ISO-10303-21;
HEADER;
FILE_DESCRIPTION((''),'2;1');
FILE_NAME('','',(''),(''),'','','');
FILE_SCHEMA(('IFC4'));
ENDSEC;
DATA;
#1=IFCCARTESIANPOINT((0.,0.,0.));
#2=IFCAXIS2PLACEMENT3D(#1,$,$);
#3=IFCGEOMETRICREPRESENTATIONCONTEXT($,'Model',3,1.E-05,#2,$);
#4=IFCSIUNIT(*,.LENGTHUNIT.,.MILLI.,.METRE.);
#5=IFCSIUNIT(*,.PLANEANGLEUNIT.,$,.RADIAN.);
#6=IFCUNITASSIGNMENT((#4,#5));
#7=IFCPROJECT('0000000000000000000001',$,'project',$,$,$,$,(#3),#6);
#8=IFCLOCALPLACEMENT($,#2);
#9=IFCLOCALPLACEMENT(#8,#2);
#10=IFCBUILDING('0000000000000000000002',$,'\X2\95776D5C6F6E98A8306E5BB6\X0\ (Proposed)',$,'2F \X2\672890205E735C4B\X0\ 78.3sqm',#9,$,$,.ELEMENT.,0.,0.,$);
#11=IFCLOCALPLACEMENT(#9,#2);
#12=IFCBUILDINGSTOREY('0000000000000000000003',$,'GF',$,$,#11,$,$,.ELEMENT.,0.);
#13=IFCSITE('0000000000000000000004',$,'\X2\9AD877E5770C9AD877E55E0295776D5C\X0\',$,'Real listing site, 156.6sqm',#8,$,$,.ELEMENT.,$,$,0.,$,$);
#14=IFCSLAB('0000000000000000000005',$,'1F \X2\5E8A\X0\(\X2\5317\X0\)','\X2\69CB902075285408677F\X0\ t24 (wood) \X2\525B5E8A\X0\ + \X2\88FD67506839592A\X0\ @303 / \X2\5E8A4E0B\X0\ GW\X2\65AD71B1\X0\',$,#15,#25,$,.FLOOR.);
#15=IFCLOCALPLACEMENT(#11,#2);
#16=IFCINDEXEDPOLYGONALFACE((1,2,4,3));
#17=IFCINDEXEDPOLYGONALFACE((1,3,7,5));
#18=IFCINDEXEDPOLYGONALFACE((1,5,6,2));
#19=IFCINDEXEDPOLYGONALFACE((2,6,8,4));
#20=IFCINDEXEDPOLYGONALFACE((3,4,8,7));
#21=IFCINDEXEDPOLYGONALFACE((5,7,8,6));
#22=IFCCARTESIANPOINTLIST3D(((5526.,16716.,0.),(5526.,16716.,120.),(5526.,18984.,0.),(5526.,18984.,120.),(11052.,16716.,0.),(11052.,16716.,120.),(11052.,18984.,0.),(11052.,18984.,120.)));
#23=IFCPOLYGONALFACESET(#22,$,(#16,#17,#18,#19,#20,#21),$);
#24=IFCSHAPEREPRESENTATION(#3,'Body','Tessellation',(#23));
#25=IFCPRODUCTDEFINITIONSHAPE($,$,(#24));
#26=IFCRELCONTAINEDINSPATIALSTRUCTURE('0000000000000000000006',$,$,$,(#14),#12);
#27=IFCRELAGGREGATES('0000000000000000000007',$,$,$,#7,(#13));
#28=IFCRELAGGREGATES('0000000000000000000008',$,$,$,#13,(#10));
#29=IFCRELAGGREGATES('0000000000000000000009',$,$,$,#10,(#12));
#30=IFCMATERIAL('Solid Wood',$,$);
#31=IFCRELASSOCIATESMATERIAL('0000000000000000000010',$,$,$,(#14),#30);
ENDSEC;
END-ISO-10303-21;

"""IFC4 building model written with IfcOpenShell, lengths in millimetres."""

from ifc_helpers import new_model, si_unit, frame, frame_2d, origin, place, context, project, spatial, rectangle, extrude, material, element, save


model = new_model("IFC4")

# Units and contexts
model_context = context("Model", 3, precision=1e-05, world=origin())
ifc_project = project(units=[si_unit("LENGTHUNIT", "METRE", prefix="MILLI"), si_unit("PLANEANGLEUNIT", "RADIAN")], contexts=[model_context])

# Site, building, storey
site_placement = place(None, origin())
site = spatial("IfcSite", under=ifc_project, at=site_placement, Name="高知県高知市長浜", ObjectType="Real listing site, 156.6sqm", CompositionType="ELEMENT", RefElevation=0.0)
building_placement = place(site_placement, origin())
building = spatial("IfcBuilding", under=site, at=building_placement, Name="長浜潮風の家 (Proposed)", ObjectType="2F 木造平屋 78.3sqm", CompositionType="ELEMENT", ElevationOfRefHeight=0.0, ElevationOfTerrain=0.0)
storey_placement = place(building_placement, origin())
storey = spatial("IfcBuildingStorey", under=building, at=storey_placement, Name="GF", CompositionType="ELEMENT", Elevation=0.0)

# Slab
ifc_material_1 = material(Name="Solid Wood")
slab_1_placement = place(storey_placement, frame((2763.0, 8358.0, 0.0)))
element("IfcSlab", 1, at=slab_1_placement, inside=storey, material=ifc_material_1, Name="1F 床(北)", Description="構造用合板 t24 (wood) 剛床 + 製材根太 @303 / 床下 GW断熱", PredefinedType="FLOOR", context=model_context, shape_type="SweptSolid", body=[
    extrude(rectangle(XDim=5526.0, YDim=2268.0, at=frame_2d((2763.0, 1134.0))), frame((2763.0, 8358.0, 0.0)), (0.0, 0.0, 1.0), 120.0),
])

save(model, "model.ifc")
